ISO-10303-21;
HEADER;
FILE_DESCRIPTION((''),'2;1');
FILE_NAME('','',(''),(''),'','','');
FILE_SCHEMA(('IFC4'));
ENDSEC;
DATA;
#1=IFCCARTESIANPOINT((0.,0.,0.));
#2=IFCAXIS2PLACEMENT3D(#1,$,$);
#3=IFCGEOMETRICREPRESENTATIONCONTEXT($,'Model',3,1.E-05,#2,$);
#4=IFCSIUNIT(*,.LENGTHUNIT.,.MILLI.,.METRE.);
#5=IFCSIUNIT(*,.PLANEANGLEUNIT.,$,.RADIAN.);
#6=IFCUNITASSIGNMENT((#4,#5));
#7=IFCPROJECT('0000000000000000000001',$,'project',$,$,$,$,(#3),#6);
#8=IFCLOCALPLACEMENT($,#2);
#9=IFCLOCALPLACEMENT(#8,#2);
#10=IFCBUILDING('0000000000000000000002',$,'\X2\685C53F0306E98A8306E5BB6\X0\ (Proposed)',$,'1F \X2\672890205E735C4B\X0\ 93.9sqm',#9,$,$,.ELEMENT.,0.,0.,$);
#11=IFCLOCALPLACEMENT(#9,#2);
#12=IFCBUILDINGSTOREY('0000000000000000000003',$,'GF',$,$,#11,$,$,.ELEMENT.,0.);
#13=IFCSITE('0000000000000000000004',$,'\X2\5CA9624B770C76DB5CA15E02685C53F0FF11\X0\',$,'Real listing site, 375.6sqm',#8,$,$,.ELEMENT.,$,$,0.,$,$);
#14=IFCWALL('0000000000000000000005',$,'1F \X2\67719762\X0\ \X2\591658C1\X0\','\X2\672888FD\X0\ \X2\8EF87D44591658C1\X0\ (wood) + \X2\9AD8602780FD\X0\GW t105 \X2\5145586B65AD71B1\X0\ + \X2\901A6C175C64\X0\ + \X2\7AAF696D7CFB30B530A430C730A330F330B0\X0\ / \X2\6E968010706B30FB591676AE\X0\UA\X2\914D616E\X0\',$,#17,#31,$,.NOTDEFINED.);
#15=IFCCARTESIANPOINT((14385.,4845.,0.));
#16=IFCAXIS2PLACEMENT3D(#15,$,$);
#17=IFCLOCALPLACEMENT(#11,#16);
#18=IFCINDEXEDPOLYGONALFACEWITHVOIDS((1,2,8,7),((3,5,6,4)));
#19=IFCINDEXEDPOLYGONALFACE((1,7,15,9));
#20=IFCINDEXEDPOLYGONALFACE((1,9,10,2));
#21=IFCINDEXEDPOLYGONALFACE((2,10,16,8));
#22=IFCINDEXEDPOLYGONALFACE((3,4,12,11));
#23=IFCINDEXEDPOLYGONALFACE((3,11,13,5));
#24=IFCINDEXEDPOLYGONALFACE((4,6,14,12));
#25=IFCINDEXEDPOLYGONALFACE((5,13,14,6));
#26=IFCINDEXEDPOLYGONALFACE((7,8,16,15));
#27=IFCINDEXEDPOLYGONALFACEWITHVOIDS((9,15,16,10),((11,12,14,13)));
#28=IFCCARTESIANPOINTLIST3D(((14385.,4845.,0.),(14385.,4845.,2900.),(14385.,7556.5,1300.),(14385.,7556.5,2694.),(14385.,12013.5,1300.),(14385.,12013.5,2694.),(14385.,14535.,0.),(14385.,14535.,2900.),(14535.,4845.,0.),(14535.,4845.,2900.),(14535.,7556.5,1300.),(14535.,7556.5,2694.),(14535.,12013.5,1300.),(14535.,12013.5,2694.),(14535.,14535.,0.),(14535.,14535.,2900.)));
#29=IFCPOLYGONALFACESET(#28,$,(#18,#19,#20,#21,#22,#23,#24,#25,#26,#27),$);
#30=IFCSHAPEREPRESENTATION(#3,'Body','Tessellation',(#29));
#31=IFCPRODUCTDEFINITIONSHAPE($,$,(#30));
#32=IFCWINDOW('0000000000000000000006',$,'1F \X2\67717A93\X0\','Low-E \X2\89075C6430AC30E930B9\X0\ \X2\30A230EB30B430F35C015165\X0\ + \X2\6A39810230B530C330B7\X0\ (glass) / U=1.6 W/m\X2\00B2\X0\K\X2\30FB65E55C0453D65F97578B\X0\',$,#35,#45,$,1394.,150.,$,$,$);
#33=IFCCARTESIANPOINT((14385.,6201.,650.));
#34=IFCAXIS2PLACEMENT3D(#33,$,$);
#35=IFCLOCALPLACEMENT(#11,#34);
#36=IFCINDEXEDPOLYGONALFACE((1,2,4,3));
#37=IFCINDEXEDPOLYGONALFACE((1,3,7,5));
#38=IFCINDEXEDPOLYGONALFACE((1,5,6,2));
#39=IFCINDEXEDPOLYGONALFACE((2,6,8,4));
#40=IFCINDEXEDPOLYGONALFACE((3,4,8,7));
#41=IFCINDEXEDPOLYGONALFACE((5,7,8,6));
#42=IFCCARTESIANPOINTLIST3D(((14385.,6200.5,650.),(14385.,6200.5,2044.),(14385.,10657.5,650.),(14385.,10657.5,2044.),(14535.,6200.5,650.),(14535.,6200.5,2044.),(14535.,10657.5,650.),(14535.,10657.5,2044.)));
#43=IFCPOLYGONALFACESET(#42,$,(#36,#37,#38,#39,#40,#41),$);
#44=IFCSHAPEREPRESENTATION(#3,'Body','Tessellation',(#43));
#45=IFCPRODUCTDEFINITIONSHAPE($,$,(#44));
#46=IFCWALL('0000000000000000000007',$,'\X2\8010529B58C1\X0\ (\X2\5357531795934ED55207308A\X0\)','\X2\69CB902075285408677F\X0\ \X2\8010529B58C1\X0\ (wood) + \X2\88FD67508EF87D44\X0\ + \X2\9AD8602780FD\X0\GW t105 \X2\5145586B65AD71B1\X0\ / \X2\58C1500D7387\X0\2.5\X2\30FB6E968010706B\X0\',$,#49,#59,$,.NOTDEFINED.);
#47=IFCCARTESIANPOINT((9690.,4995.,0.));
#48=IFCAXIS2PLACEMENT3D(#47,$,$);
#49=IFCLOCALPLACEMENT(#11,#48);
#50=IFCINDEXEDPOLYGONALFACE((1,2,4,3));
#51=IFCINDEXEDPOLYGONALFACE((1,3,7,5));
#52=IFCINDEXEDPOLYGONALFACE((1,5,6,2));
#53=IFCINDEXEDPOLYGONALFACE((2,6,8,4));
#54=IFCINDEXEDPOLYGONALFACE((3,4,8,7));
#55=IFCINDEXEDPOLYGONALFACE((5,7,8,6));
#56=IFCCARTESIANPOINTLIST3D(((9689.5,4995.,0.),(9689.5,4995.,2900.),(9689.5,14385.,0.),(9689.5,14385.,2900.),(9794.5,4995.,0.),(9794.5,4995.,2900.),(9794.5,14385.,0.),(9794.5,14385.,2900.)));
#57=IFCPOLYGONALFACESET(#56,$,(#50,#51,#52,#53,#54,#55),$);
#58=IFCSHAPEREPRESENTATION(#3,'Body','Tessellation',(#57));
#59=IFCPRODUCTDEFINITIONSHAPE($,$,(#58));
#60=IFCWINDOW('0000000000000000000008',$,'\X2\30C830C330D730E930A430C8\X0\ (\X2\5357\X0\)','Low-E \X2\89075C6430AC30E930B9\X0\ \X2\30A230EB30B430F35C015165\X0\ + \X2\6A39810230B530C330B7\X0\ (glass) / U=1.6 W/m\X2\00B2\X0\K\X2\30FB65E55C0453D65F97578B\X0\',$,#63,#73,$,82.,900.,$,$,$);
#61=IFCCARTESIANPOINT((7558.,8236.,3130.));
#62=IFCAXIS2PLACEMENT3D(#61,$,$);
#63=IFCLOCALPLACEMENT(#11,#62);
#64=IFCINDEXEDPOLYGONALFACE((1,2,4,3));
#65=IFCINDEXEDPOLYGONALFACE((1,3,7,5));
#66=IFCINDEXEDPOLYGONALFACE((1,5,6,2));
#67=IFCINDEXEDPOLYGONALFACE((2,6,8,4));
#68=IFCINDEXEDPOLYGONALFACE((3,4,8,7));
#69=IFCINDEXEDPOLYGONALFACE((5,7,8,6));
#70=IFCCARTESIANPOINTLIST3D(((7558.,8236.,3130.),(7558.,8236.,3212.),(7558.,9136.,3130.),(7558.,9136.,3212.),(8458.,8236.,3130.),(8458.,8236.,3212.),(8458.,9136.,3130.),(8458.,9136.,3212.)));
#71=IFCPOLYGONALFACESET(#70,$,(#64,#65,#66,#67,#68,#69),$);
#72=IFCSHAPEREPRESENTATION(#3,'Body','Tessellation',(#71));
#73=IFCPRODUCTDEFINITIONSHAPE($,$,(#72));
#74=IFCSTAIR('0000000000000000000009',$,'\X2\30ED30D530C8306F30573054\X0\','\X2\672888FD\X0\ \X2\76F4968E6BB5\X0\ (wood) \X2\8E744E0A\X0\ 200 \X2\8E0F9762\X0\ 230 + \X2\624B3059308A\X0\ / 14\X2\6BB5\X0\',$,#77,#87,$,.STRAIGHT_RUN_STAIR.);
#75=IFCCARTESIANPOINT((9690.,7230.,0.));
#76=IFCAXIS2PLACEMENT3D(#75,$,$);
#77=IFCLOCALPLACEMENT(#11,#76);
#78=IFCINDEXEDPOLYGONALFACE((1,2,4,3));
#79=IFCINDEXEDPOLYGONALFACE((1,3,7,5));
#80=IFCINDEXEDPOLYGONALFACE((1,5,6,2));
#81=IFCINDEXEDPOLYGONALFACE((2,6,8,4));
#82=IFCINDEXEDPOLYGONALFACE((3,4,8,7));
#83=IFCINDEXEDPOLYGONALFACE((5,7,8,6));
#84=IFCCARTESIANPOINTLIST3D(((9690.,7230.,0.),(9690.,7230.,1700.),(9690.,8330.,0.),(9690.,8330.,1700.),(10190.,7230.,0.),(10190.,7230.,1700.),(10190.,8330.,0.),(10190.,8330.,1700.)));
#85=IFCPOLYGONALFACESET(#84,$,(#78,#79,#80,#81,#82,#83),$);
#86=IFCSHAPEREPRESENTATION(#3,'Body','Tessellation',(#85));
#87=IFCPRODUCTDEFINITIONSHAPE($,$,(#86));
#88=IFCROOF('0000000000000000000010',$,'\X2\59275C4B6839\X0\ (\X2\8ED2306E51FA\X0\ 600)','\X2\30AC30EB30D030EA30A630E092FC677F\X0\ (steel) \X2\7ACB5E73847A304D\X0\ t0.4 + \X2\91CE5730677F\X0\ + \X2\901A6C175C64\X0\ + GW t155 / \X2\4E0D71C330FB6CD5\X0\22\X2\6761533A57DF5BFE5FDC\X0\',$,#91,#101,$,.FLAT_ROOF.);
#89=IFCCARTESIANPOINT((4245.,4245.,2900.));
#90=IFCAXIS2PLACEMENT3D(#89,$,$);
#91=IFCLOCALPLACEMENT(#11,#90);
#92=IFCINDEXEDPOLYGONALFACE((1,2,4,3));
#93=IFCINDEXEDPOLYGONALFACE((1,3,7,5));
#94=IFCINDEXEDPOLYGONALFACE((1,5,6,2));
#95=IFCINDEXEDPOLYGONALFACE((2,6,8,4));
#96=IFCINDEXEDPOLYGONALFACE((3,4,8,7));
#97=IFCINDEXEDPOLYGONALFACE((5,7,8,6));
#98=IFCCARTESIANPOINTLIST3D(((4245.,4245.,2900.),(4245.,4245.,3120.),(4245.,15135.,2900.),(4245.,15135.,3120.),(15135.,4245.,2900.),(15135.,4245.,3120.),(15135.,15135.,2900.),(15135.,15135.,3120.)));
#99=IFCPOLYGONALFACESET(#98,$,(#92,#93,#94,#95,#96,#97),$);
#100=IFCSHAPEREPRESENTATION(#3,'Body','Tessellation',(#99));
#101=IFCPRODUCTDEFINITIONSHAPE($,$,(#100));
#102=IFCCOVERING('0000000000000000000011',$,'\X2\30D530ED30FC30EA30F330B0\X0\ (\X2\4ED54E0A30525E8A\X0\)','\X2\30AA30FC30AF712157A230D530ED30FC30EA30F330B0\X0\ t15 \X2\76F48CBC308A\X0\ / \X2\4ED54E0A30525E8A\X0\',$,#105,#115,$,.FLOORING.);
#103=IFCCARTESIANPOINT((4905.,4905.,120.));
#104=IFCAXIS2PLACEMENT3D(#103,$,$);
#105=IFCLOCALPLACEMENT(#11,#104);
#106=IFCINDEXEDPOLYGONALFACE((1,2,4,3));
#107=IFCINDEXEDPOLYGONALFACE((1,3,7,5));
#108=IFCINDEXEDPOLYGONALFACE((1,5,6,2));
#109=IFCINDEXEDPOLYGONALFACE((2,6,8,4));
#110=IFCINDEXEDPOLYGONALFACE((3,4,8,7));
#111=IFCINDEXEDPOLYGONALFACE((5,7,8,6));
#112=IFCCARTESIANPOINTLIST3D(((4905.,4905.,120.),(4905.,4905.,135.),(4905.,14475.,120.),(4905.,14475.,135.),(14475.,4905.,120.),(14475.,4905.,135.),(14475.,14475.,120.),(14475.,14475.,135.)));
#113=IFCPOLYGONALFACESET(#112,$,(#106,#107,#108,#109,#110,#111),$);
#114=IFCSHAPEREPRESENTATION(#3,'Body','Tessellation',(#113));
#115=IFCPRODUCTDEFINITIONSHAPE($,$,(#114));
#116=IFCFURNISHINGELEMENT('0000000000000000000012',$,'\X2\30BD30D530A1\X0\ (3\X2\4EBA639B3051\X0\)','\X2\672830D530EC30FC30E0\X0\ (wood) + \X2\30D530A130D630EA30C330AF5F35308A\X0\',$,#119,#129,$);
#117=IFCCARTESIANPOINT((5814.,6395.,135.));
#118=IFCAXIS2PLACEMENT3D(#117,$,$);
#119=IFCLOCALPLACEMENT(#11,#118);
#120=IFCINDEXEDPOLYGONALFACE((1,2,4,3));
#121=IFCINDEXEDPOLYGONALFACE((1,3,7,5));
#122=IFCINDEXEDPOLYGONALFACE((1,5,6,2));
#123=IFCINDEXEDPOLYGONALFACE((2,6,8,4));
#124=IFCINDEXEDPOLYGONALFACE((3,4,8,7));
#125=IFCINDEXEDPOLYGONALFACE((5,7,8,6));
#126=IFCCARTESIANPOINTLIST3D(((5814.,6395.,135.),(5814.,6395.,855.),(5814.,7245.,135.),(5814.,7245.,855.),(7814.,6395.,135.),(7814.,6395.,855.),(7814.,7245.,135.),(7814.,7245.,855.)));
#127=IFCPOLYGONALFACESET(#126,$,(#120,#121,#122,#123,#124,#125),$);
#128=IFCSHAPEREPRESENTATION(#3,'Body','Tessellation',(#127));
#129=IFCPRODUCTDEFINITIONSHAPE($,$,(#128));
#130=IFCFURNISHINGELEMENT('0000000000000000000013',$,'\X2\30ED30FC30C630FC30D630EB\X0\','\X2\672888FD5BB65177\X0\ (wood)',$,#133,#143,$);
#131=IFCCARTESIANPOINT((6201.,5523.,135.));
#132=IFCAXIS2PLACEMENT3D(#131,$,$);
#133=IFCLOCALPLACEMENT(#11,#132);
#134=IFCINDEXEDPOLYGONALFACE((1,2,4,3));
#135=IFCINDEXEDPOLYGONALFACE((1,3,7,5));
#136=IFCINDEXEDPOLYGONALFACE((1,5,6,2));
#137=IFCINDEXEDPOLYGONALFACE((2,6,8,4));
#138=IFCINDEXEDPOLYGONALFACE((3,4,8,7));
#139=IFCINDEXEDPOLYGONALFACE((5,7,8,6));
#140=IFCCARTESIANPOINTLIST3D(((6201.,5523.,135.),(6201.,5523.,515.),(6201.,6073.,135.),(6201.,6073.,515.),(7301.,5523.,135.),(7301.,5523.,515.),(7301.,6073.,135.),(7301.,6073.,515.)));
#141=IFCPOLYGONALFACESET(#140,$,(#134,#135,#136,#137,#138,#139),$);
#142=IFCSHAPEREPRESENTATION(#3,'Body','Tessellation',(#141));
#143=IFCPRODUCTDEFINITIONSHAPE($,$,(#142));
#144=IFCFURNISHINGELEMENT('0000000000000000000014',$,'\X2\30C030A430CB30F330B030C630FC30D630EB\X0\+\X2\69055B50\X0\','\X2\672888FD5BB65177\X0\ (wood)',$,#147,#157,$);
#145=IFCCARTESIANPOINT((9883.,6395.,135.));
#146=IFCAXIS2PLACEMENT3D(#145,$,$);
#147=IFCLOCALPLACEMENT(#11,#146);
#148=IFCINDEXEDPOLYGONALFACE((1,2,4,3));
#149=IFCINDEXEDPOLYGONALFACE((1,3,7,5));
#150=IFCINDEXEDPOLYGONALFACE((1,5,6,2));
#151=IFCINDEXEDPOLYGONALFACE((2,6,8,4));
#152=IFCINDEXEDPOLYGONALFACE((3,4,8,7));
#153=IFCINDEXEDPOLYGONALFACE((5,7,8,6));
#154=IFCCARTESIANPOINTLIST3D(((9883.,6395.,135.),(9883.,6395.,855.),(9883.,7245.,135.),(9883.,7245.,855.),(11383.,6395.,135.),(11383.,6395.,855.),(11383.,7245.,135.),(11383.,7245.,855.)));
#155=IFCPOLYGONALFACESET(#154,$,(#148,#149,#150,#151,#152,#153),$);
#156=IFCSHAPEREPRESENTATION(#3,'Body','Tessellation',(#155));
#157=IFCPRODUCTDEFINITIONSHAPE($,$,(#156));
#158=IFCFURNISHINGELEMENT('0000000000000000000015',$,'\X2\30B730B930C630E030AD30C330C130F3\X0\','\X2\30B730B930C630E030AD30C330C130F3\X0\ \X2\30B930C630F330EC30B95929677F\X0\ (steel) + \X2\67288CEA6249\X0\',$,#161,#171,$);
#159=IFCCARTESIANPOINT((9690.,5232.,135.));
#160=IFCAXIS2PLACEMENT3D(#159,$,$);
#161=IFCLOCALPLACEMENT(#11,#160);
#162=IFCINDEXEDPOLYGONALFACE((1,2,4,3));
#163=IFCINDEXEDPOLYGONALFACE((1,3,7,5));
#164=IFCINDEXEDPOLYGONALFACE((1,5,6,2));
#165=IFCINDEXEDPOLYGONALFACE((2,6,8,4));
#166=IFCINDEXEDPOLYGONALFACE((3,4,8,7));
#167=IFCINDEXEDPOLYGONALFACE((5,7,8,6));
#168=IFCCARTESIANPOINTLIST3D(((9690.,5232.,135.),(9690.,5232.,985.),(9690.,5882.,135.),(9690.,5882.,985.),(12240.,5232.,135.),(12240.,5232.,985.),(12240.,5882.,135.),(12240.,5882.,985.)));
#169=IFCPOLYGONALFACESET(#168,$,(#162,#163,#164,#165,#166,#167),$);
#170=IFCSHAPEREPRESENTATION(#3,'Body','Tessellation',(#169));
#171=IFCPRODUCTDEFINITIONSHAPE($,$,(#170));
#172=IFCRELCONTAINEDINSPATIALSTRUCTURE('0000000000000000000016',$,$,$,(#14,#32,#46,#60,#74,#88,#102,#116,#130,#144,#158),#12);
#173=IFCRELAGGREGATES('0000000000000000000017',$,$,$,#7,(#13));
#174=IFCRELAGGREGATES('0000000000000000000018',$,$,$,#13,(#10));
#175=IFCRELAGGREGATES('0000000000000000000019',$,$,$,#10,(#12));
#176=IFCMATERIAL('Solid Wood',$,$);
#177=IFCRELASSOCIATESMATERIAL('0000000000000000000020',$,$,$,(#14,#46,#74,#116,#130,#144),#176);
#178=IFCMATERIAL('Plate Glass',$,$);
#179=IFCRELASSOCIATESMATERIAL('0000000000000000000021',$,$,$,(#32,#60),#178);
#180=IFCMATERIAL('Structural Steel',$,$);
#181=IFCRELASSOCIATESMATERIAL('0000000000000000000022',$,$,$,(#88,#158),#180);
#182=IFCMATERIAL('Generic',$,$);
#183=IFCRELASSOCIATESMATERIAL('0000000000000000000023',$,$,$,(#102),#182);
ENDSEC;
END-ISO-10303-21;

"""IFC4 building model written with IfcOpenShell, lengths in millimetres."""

from ifc_helpers import new_model, si_unit, frame, frame_2d, origin, place, context, project, spatial, rectangle, extrude, material, element, fill, save


model = new_model("IFC4")

# Units and contexts
model_context = context("Model", 3, precision=1e-05, world=origin())
ifc_project = project(units=[si_unit("LENGTHUNIT", "METRE", prefix="MILLI"), si_unit("PLANEANGLEUNIT", "RADIAN")], contexts=[model_context])

# Site, building, storey
site_placement = place(None, origin())
site = spatial("IfcSite", under=ifc_project, at=site_placement, Name="岩手県盛岡市桜台１", ObjectType="Real listing site, 375.6sqm", CompositionType="ELEMENT", RefElevation=0.0)
building_placement = place(site_placement, origin())
building = spatial("IfcBuilding", under=site, at=building_placement, Name="桜台の風の家 (Proposed)", ObjectType="1F 木造平屋 93.9sqm", CompositionType="ELEMENT", ElevationOfRefHeight=0.0, ElevationOfTerrain=0.0)
storey_placement = place(building_placement, origin())
storey = spatial("IfcBuildingStorey", under=building, at=storey_placement, Name="GF", CompositionType="ELEMENT", Elevation=0.0)

# Shared definitions
ifc_material_1 = material(Name="Solid Wood")

# Shared definitions
ifc_material_2 = material(Name="Plate Glass")

# Wall, opening, window
wall_1_placement = place(storey_placement, frame((14385.0, 4845.0, 0.0)))
wall_1 = element("IfcWall", 1, at=wall_1_placement, inside=storey, material=ifc_material_1, Name="1F 東面 外壁", Description="木製 軸組外壁 (wood) + 高性能GW t105 充填断熱 + 通気層 + 窯業系サイディング / 準耐火・外皮UA配慮", PredefinedType="NOTDEFINED", context=model_context, shape_type="SweptSolid", body=[
    extrude(rectangle(XDim=150.0, YDim=9690.0, at=frame_2d((75.0, 4845.0))), frame((14385.0, 4845.0, 0.0)), (0.0, 0.0, 1.0), 2900.0),
])
opening_1_placement = place(storey_placement, frame((14385.0, 6201.0, 650.0)))
opening_1 = element("IfcOpeningElement", 2, at=opening_1_placement, cuts=wall_1, PredefinedType="NOTDEFINED", context=model_context, shape_type="SweptSolid", body=[
    extrude(rectangle(XDim=150.0, YDim=4457.0, at=frame_2d((75.0, 2228.0))), frame((14385.0, 6201.0, 650.0)), (0.0, 0.0, 1.0), 1394.0),
])
window_1_placement = place(storey_placement, frame((14385.0, 6201.0, 650.0)))
window_1 = element("IfcWindow", 3, at=window_1_placement, inside=storey, material=ifc_material_2, Name="1F 東窓", Description="Low-E 複層ガラス アルゴン封入 + 樹脂サッシ (glass) / U=1.6 W/m²K・日射取得型", OverallHeight=1394.0, OverallWidth=150.0, context=model_context, shape_type="SweptSolid", body=[
    extrude(rectangle(XDim=150.0, YDim=4457.0, at=frame_2d((75.0, 2228.0))), frame((14385.0, 6201.0, 650.0)), (0.0, 0.0, 1.0), 1394.0),
])
fill(opening_1, window_1)

# Wall
wall_2_placement = place(storey_placement, frame((9690.0, 4995.0, 0.0)))
element("IfcWall", 4, at=wall_2_placement, inside=storey, material=ifc_material_1, Name="耐力壁 (南北間仕切り)", Description="構造用合板 耐力壁 (wood) + 製材軸組 + 高性能GW t105 充填断熱 / 壁倍率2.5・準耐火", PredefinedType="NOTDEFINED", context=model_context, shape_type="SweptSolid", body=[
    extrude(rectangle(XDim=105.0, YDim=9390.0, at=frame_2d((52.0, 4695.0))), frame((9690.0, 4995.0, 0.0)), (0.0, 0.0, 1.0), 2900.0),
])

# Window
window_2_placement = place(storey_placement, frame((7558.0, 8236.0, 3130.0)))
element("IfcWindow", 5, at=window_2_placement, inside=storey, material=ifc_material_2, Name="トップライト (南)", Description="Low-E 複層ガラス アルゴン封入 + 樹脂サッシ (glass) / U=1.6 W/m²K・日射取得型", OverallHeight=82.0, OverallWidth=900.0, context=model_context, shape_type="SweptSolid", body=[
    extrude(rectangle(XDim=900.0, YDim=900.0, at=frame_2d((450.0, 450.0))), frame((7558.0, 8236.0, 3130.0)), (0.0, 0.0, 1.0), 82.0),
])

# Stair
stair_placement = place(storey_placement, frame((9690.0, 7230.0, 0.0)))
element("IfcStair", 6, at=stair_placement, inside=storey, material=ifc_material_1, Name="ロフトはしご", Description="木製 直階段 (wood) 蹴上 200 踏面 230 + 手すり / 14段", PredefinedType="STRAIGHT_RUN_STAIR", context=model_context, shape_type="SweptSolid", body=[
    extrude(rectangle(XDim=500.0, YDim=1100.0, at=frame_2d((250.0, 550.0))), frame((9690.0, 7230.0, 0.0)), (0.0, 0.0, 1.0), 1700.0),
])

# Roof
ifc_material_3 = material(Name="Structural Steel")
roof_placement = place(storey_placement, frame((4245.0, 4245.0, 2900.0)))
element("IfcRoof", 7, at=roof_placement, inside=storey, material=ifc_material_3, Name="大屋根 (軒の出 600)", Description="ガルバリウム鋼板 (steel) 立平葺き t0.4 + 野地板 + 通気層 + GW t155 / 不燃・法22条区域対応", PredefinedType="FLAT_ROOF", context=model_context, shape_type="SweptSolid", body=[
    extrude(rectangle(XDim=10890.0, YDim=10890.0, at=frame_2d((5445.0, 5445.0))), frame((4245.0, 4245.0, 2900.0)), (0.0, 0.0, 1.0), 220.0),
])

# Covering
ifc_material_4 = material(Name="Generic")
covering_placement = place(storey_placement, frame((4905.0, 4905.0, 120.0)))
element("IfcCovering", 8, at=covering_placement, inside=storey, material=ifc_material_4, Name="フローリング (仕上げ床)", Description="オーク無垢フローリング t15 直貼り / 仕上げ床", PredefinedType="FLOORING", context=model_context, shape_type="SweptSolid", body=[
    extrude(rectangle(XDim=9570.0, YDim=9570.0, at=frame_2d((4785.0, 4785.0))), frame((4905.0, 4905.0, 120.0)), (0.0, 0.0, 1.0), 15.0),
])

# Furnishing elements
furnishing_1_placement = place(storey_placement, frame((5814.0, 6395.0, 135.0)))
element("IfcFurnishingElement", 9, at=furnishing_1_placement, inside=storey, material=ifc_material_1, Name="ソファ (3人掛け)", Description="木フレーム (wood) + ファブリック張り", context=model_context, shape_type="SweptSolid", body=[
    extrude(rectangle(XDim=2000.0, YDim=850.0, at=frame_2d((1000.0, 425.0))), frame((5814.0, 6395.0, 135.0)), (0.0, 0.0, 1.0), 720.0),
])
furnishing_2_placement = place(storey_placement, frame((6201.0, 5523.0, 135.0)))
element("IfcFurnishingElement", 10, at=furnishing_2_placement, inside=storey, material=ifc_material_1, Name="ローテーブル", Description="木製家具 (wood)", context=model_context, shape_type="SweptSolid", body=[
    extrude(rectangle(XDim=1100.0, YDim=550.0, at=frame_2d((550.0, 275.0))), frame((6201.0, 5523.0, 135.0)), (0.0, 0.0, 1.0), 380.0),
])
furnishing_3_placement = place(storey_placement, frame((9883.0, 6395.0, 135.0)))
element("IfcFurnishingElement", 11, at=furnishing_3_placement, inside=storey, material=ifc_material_1, Name="ダイニングテーブル+椅子", Description="木製家具 (wood)", context=model_context, shape_type="SweptSolid", body=[
    extrude(rectangle(XDim=1500.0, YDim=850.0, at=frame_2d((750.0, 425.0))), frame((9883.0, 6395.0, 135.0)), (0.0, 0.0, 1.0), 720.0),
])
furnishing_4_placement = place(storey_placement, frame((9690.0, 5232.0, 135.0)))
element("IfcFurnishingElement", 12, at=furnishing_4_placement, inside=storey, material=ifc_material_3, Name="システムキッチン", Description="システムキッチン ステンレス天板 (steel) + 木質扉", context=model_context, shape_type="SweptSolid", body=[
    extrude(rectangle(XDim=2550.0, YDim=650.0, at=frame_2d((1275.0, 325.0))), frame((9690.0, 5232.0, 135.0)), (0.0, 0.0, 1.0), 850.0),
])

save(model, "model.ifc")
